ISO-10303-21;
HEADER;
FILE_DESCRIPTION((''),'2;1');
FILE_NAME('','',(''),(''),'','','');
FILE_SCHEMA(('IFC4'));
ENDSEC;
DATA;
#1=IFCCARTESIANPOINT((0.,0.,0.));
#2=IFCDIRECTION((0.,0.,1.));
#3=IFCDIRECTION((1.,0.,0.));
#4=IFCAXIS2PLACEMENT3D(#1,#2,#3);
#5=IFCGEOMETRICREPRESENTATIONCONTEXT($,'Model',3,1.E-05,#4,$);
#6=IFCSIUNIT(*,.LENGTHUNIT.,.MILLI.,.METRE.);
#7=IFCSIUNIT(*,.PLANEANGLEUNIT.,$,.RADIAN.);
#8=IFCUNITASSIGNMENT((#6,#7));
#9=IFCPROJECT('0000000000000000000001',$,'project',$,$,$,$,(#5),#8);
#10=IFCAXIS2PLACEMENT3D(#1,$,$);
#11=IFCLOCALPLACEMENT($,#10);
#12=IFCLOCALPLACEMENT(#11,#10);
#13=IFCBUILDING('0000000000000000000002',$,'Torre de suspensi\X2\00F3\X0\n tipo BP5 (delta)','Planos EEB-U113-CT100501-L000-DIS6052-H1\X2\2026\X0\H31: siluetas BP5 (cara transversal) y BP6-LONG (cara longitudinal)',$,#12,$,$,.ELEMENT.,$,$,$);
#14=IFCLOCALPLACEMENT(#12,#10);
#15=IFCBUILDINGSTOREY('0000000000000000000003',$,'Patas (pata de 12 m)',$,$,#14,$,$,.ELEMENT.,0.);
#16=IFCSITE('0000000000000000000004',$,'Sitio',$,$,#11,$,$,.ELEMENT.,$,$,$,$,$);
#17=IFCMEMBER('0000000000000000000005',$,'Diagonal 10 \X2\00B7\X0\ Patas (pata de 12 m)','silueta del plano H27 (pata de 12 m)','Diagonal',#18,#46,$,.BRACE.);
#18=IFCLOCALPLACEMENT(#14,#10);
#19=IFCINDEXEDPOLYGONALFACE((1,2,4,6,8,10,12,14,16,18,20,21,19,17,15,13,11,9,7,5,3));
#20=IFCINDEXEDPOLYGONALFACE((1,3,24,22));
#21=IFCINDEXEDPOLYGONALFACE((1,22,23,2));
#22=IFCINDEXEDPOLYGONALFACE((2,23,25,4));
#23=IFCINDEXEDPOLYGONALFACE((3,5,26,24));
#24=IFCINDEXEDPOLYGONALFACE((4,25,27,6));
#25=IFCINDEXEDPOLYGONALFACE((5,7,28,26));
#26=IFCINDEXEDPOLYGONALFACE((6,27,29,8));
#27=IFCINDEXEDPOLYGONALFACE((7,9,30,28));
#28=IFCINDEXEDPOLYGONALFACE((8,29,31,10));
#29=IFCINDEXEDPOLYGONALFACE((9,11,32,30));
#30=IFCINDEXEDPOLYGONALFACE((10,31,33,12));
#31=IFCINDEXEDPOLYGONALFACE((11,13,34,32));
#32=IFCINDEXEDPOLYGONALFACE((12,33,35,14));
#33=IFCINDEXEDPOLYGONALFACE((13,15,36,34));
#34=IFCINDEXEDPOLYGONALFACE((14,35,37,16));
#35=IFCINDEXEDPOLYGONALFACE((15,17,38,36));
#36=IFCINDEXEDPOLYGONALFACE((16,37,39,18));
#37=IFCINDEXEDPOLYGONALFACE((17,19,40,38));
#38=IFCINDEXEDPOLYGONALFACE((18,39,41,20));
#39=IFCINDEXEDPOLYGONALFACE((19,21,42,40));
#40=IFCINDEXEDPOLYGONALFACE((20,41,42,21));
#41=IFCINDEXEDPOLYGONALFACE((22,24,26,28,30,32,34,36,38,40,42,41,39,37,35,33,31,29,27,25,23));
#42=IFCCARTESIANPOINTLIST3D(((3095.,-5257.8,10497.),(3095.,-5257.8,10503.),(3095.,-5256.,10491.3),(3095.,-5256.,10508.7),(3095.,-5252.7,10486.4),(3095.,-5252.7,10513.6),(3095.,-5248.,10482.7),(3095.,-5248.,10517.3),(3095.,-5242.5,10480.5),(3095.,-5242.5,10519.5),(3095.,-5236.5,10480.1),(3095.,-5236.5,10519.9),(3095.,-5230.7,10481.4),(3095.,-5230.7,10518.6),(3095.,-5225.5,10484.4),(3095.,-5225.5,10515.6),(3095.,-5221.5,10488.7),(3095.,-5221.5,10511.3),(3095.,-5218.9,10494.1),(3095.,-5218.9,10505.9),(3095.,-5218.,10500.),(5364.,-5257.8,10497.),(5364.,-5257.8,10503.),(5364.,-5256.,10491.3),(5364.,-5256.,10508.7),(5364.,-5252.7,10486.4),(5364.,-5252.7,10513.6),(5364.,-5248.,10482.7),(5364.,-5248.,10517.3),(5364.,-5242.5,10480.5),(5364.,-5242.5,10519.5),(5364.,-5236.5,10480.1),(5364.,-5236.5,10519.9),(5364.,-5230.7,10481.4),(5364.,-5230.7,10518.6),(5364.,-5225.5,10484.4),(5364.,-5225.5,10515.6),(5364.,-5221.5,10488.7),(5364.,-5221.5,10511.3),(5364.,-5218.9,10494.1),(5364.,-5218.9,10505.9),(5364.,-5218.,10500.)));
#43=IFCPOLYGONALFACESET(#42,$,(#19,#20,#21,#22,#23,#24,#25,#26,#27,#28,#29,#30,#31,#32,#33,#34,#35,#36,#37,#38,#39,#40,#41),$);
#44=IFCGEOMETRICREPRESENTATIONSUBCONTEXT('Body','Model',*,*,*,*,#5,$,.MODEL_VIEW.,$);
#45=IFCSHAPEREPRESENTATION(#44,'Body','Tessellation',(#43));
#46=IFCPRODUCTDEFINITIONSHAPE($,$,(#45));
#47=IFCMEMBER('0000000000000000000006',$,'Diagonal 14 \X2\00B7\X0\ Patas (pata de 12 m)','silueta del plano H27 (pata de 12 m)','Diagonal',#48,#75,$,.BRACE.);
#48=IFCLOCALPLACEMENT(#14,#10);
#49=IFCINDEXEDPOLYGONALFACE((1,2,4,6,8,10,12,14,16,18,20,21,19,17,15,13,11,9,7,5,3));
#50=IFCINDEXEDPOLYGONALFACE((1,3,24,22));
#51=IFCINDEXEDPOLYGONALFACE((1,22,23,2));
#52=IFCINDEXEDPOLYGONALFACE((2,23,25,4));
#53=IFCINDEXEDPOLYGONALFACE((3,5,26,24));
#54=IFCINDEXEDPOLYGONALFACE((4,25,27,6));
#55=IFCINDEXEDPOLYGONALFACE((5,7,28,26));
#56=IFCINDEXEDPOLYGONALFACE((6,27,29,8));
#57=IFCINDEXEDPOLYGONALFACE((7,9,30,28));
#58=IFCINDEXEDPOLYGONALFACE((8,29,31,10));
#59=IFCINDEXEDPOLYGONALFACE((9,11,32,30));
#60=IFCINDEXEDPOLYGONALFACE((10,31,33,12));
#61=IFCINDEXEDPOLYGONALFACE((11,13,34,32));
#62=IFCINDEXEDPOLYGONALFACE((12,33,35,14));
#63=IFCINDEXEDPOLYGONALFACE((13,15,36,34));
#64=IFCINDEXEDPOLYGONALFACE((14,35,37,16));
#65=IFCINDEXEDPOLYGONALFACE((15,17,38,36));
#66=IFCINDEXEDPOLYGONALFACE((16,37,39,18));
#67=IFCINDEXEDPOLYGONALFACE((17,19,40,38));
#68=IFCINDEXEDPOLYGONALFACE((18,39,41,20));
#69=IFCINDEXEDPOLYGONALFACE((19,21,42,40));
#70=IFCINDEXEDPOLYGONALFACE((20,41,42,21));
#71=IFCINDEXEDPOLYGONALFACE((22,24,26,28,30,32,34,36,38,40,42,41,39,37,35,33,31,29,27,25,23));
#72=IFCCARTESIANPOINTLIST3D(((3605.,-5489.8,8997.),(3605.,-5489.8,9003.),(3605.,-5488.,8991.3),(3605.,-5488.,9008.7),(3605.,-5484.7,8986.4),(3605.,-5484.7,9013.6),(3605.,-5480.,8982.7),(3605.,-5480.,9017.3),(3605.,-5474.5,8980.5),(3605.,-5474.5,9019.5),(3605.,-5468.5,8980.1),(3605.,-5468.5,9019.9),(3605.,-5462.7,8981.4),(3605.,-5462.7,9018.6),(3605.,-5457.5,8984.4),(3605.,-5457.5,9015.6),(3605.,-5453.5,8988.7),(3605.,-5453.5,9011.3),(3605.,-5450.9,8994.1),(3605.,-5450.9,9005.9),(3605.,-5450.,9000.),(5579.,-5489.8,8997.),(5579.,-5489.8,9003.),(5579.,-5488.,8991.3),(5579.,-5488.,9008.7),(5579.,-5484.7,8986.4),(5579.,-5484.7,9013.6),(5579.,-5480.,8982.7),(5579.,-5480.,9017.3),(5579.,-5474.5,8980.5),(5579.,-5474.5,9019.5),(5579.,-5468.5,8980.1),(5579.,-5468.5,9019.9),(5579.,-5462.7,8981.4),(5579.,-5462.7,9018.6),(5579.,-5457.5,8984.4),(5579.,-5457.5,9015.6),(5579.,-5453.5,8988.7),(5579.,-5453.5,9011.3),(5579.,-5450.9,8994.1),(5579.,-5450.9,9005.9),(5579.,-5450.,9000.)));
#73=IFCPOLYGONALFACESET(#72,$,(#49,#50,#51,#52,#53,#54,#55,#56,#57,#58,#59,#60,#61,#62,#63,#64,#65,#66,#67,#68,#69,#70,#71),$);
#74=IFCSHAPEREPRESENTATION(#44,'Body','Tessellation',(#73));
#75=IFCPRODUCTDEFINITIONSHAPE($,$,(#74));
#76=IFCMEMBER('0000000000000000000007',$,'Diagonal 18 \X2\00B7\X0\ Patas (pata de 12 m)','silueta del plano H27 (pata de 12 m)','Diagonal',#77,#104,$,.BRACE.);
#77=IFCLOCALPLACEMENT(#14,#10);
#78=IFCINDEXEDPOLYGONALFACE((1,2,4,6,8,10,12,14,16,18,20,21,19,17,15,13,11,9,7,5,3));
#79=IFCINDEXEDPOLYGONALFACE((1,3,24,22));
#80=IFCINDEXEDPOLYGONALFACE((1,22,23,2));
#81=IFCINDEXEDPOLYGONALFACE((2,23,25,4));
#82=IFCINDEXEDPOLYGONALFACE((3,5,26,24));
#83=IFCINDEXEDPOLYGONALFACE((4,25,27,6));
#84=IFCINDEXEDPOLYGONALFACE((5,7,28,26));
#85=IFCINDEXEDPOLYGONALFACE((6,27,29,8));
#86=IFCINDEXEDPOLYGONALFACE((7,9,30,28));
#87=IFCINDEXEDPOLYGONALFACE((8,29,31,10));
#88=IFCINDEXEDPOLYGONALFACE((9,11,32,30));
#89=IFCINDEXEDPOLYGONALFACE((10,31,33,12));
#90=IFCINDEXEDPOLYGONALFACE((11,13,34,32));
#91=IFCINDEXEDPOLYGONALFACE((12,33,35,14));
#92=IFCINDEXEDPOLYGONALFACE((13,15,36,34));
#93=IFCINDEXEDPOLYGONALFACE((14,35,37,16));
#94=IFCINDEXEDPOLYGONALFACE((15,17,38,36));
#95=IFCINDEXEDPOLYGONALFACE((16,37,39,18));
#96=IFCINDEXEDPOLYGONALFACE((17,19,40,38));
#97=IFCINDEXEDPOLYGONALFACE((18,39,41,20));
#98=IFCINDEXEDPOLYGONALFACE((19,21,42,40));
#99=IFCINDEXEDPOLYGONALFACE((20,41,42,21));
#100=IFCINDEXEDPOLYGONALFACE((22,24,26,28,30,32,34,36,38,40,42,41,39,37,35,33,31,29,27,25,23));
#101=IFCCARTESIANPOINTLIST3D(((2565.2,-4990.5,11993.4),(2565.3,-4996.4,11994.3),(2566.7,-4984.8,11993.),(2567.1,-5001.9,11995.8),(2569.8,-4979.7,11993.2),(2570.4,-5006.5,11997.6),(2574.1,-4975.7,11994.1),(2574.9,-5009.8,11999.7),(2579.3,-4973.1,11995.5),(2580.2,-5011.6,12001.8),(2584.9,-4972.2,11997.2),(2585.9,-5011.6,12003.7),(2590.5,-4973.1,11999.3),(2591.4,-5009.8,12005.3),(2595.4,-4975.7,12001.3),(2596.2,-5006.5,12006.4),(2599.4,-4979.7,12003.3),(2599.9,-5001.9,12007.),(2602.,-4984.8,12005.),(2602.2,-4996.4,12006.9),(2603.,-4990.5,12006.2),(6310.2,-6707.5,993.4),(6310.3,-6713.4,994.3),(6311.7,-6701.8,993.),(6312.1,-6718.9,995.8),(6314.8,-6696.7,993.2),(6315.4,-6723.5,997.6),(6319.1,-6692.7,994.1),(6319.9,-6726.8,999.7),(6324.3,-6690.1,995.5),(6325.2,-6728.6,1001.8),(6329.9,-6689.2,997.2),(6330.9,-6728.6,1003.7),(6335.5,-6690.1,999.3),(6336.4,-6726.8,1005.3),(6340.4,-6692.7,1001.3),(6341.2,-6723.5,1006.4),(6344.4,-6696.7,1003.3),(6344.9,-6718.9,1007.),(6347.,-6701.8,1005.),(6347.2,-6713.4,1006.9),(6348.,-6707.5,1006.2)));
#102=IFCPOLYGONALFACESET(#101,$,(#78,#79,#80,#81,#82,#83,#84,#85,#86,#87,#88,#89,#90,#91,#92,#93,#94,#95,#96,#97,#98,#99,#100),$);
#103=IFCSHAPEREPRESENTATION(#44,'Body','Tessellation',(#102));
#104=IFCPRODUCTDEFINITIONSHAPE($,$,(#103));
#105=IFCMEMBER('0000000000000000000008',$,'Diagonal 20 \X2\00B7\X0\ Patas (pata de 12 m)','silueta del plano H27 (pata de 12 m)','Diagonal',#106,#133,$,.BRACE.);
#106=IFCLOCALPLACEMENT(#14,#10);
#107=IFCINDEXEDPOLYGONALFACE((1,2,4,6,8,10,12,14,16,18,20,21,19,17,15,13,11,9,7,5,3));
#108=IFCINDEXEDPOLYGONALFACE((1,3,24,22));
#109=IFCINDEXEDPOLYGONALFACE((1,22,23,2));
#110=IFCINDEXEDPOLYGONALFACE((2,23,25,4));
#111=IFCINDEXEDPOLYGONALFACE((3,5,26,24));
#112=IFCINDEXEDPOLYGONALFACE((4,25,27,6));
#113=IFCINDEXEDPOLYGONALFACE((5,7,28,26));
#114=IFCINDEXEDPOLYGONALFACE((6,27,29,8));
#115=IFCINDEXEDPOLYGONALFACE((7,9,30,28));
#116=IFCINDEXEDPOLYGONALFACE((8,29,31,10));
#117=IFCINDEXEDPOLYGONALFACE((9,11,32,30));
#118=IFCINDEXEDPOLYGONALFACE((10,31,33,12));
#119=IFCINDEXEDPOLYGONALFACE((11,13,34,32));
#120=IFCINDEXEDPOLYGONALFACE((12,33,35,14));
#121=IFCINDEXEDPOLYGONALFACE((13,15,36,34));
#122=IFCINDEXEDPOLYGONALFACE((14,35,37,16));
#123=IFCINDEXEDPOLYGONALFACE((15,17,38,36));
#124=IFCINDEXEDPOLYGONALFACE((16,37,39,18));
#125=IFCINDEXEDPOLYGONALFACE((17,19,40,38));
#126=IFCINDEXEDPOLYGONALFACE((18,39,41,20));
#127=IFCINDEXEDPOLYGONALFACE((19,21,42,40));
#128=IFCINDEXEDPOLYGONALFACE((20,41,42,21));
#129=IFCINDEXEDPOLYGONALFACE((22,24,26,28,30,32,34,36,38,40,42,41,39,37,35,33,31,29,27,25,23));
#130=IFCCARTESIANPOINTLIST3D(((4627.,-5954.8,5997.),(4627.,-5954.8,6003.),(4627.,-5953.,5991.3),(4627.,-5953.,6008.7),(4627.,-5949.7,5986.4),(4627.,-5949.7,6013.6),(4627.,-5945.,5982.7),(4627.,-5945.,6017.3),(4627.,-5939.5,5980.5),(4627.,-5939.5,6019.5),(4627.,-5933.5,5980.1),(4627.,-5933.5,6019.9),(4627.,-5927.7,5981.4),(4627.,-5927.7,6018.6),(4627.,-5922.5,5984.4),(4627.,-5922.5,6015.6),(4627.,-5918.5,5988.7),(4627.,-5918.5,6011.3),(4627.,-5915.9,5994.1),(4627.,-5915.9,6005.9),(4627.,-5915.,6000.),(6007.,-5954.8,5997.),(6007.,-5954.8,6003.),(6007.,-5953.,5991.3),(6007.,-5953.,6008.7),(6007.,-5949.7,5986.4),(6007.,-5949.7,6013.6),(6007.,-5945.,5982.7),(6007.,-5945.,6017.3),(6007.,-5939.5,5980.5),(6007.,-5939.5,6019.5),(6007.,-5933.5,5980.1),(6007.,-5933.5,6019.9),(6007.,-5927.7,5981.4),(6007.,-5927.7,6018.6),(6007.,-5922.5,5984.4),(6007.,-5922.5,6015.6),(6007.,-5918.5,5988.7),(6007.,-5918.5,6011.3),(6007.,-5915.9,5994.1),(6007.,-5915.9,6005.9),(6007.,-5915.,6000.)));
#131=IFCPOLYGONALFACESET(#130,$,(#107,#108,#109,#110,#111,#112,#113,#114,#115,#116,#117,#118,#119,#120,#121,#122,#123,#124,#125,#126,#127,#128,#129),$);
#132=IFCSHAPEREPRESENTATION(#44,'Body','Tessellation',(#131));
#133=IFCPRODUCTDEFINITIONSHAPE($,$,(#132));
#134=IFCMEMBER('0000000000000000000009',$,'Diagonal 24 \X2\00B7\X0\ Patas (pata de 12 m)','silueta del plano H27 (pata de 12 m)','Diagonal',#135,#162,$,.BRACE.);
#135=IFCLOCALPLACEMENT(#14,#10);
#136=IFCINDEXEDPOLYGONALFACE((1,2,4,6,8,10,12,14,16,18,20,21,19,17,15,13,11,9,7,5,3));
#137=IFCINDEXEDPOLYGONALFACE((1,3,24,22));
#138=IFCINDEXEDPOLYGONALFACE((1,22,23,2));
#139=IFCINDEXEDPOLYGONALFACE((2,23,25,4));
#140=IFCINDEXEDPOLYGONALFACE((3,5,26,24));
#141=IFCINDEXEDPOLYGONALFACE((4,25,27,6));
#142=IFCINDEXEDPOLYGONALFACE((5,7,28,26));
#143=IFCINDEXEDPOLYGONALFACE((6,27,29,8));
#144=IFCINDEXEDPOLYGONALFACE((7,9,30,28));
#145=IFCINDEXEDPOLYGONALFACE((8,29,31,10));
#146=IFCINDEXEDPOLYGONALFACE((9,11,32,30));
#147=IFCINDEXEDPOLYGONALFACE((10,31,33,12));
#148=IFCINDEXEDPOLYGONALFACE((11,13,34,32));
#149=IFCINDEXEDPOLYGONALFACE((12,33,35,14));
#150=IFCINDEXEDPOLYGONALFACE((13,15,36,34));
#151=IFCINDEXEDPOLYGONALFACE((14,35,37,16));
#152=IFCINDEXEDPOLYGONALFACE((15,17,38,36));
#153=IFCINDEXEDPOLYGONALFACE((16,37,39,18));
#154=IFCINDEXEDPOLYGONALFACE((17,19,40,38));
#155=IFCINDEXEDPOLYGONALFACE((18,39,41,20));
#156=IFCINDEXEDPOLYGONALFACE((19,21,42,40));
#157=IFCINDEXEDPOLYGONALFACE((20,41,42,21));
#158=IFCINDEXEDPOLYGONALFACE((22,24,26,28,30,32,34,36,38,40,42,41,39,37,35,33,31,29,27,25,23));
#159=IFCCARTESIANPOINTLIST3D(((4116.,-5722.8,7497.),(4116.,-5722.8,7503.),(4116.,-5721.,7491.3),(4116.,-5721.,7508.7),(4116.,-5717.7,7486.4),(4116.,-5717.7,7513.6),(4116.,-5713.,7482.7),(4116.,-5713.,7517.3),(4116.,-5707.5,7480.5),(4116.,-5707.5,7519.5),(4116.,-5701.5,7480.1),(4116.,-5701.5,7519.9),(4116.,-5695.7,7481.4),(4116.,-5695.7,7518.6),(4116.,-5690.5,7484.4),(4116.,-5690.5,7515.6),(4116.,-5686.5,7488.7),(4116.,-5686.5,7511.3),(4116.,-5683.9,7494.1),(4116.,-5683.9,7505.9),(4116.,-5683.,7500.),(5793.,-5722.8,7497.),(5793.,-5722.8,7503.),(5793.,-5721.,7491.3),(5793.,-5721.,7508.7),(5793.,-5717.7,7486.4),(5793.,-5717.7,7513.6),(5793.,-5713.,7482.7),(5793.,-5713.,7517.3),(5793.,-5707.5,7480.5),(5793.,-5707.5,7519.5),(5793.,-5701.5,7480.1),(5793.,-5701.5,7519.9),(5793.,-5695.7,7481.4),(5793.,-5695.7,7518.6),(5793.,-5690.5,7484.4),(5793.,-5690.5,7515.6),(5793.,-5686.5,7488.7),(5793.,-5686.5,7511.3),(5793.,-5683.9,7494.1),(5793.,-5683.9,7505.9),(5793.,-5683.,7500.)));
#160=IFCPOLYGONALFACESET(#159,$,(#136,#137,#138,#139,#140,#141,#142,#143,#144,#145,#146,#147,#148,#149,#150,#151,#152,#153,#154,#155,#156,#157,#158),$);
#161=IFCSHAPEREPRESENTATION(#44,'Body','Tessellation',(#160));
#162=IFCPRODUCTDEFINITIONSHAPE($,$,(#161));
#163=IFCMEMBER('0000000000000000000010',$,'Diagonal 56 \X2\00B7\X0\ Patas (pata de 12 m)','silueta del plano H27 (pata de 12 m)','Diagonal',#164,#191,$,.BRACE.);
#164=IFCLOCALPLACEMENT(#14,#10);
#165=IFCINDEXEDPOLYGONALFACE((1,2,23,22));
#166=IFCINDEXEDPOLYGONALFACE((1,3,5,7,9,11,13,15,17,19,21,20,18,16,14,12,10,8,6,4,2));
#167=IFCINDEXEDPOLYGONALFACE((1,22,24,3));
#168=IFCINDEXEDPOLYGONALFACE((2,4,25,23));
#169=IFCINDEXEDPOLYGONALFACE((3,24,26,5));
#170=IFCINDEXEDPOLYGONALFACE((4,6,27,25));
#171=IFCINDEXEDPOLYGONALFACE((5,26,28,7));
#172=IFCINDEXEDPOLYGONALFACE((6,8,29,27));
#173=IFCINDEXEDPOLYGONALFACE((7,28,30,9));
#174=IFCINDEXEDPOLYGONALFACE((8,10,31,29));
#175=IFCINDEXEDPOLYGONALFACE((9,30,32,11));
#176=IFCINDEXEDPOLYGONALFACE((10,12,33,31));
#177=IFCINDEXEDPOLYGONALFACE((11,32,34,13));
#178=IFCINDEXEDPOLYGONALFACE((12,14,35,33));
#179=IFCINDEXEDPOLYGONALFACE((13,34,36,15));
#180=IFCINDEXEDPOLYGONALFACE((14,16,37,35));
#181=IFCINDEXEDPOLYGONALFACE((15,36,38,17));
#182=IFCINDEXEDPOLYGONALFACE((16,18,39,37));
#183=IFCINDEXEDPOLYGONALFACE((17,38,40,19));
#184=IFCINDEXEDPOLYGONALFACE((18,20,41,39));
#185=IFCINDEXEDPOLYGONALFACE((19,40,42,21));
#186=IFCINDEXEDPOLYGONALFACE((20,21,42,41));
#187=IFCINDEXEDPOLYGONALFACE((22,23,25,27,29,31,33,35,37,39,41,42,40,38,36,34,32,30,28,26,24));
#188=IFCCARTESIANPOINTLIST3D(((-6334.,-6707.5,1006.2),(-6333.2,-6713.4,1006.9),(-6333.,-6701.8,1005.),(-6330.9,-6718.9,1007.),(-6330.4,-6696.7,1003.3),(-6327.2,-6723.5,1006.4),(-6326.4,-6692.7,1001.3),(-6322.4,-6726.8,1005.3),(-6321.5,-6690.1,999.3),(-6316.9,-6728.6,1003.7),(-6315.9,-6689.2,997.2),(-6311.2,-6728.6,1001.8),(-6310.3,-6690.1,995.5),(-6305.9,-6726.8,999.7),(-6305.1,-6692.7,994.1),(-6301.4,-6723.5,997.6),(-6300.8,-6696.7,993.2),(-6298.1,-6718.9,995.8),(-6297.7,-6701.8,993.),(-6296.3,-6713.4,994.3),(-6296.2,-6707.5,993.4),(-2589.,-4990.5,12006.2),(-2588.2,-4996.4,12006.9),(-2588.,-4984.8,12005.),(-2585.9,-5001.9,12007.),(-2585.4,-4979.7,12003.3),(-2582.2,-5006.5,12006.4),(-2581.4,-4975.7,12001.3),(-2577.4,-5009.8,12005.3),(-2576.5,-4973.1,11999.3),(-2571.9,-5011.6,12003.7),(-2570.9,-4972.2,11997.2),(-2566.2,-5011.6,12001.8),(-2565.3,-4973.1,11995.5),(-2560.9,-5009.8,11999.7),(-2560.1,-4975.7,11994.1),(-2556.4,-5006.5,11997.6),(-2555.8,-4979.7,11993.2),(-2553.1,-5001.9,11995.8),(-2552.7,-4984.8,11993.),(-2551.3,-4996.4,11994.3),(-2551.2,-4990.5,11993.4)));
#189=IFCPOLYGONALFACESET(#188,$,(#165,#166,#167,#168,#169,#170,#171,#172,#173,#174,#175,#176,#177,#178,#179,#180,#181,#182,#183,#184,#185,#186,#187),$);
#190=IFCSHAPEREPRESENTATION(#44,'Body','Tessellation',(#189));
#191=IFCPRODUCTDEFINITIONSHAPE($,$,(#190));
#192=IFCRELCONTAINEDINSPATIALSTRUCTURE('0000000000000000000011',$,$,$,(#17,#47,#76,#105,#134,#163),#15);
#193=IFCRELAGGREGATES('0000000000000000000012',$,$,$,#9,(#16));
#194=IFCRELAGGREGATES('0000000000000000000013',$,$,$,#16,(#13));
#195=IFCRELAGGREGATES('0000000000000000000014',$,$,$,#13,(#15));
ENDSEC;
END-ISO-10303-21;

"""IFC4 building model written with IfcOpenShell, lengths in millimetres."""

from ifc_helpers import new_model, si_unit, frame, origin, origin_with_axes, place, context, subcontext, project, spatial, circle, extrude, element, save


model = new_model("IFC4")

# Units and contexts
model_context = context("Model", 3, precision=1e-05, world=origin_with_axes())
body_context = subcontext(model_context, "Body", "Model", "MODEL_VIEW")
ifc_project = project(units=[si_unit("LENGTHUNIT", "METRE", prefix="MILLI"), si_unit("PLANEANGLEUNIT", "RADIAN")], contexts=[model_context])

# Site, building, storey
site_placement = place(None, origin())
site = spatial("IfcSite", under=ifc_project, at=site_placement, Name="Sitio", CompositionType="ELEMENT")
building_placement = place(site_placement, origin())
building = spatial("IfcBuilding", under=site, at=building_placement, Name="Torre de suspensión tipo BP5 (delta)", Description="Planos EEB-U113-CT100501-L000-DIS6052-H1…H31: siluetas BP5 (cara transversal) y BP6-LONG (cara longitudinal)", CompositionType="ELEMENT")
storey_placement = place(building_placement, origin())
storey = spatial("IfcBuildingStorey", under=building, at=storey_placement, Name="Patas (pata de 12 m)", CompositionType="ELEMENT", Elevation=0.0)

# Members
member_1_placement = place(storey_placement, frame((3095.0, -5238.0, 10500.0), z_axis=(1.0, 0.0, 0.0), x_axis=(0.0, 1.0, 0.0)))
element("IfcMember", 1, at=member_1_placement, inside=storey, Name="Diagonal 10 · Patas (pata de 12 m)", Description="silueta del plano H27 (pata de 12 m)", ObjectType="Diagonal", PredefinedType="BRACE", context=body_context, shape_type="SweptSolid", body=[
    extrude(circle(Radius=20.0), None, (0.0, 0.0, 1.0), 2269.0),
])
member_2_placement = place(storey_placement, frame((5579.0, -5470.0, 9000.0), z_axis=(-1.0, 0.0, 0.0), x_axis=(0.0, 1.0, 0.0)))
element("IfcMember", 2, at=member_2_placement, inside=storey, Name="Diagonal 14 · Patas (pata de 12 m)", Description="silueta del plano H27 (pata de 12 m)", ObjectType="Diagonal", PredefinedType="BRACE", context=body_context, shape_type="SweptSolid", body=[
    extrude(circle(Radius=20.0), None, (0.0, 0.0, 1.0), 1974.0),
])
member_3_placement = place(storey_placement, frame((2584.0, -4992.0, 12000.0), z_axis=(0.318827, -0.146175, -0.936473), x_axis=(0.047111, 0.989259, -0.138375)))
element("IfcMember", 3, at=member_3_placement, inside=storey, Name="Diagonal 18 · Patas (pata de 12 m)", Description="silueta del plano H27 (pata de 12 m)", ObjectType="Diagonal", PredefinedType="BRACE", context=body_context, shape_type="SweptSolid", body=[
    extrude(circle(Radius=20.0), None, (0.0, 0.0, 1.0), 11746.2),
])
member_4_placement = place(storey_placement, frame((6007.0, -5935.0, 6000.0), z_axis=(-1.0, 0.0, 0.0), x_axis=(0.0, 1.0, 0.0)))
element("IfcMember", 4, at=member_4_placement, inside=storey, Name="Diagonal 20 · Patas (pata de 12 m)", Description="silueta del plano H27 (pata de 12 m)", ObjectType="Diagonal", PredefinedType="BRACE", context=body_context, shape_type="SweptSolid", body=[
    extrude(circle(Radius=20.0), None, (0.0, 0.0, 1.0), 1380.0),
])
member_5_placement = place(storey_placement, frame((5793.0, -5703.0, 7500.0), z_axis=(-1.0, 0.0, 0.0), x_axis=(0.0, 1.0, 0.0)))
element("IfcMember", 5, at=member_5_placement, inside=storey, Name="Diagonal 24 · Patas (pata de 12 m)", Description="silueta del plano H27 (pata de 12 m)", ObjectType="Diagonal", PredefinedType="BRACE", context=body_context, shape_type="SweptSolid", body=[
    extrude(circle(Radius=20.0), None, (0.0, 0.0, 1.0), 1677.0),
])
member_6_placement = place(storey_placement, frame((-2570.0, -4992.0, 12000.0), z_axis=(-0.318827, -0.146175, -0.936473), x_axis=(-0.047111, 0.989259, -0.138375)))
element("IfcMember", 6, at=member_6_placement, inside=storey, Name="Diagonal 56 · Patas (pata de 12 m)", Description="silueta del plano H27 (pata de 12 m)", ObjectType="Diagonal", PredefinedType="BRACE", context=body_context, shape_type="SweptSolid", body=[
    extrude(circle(Radius=20.0), None, (0.0, 0.0, 1.0), 11746.2),
])

save(model, "model.ifc")
